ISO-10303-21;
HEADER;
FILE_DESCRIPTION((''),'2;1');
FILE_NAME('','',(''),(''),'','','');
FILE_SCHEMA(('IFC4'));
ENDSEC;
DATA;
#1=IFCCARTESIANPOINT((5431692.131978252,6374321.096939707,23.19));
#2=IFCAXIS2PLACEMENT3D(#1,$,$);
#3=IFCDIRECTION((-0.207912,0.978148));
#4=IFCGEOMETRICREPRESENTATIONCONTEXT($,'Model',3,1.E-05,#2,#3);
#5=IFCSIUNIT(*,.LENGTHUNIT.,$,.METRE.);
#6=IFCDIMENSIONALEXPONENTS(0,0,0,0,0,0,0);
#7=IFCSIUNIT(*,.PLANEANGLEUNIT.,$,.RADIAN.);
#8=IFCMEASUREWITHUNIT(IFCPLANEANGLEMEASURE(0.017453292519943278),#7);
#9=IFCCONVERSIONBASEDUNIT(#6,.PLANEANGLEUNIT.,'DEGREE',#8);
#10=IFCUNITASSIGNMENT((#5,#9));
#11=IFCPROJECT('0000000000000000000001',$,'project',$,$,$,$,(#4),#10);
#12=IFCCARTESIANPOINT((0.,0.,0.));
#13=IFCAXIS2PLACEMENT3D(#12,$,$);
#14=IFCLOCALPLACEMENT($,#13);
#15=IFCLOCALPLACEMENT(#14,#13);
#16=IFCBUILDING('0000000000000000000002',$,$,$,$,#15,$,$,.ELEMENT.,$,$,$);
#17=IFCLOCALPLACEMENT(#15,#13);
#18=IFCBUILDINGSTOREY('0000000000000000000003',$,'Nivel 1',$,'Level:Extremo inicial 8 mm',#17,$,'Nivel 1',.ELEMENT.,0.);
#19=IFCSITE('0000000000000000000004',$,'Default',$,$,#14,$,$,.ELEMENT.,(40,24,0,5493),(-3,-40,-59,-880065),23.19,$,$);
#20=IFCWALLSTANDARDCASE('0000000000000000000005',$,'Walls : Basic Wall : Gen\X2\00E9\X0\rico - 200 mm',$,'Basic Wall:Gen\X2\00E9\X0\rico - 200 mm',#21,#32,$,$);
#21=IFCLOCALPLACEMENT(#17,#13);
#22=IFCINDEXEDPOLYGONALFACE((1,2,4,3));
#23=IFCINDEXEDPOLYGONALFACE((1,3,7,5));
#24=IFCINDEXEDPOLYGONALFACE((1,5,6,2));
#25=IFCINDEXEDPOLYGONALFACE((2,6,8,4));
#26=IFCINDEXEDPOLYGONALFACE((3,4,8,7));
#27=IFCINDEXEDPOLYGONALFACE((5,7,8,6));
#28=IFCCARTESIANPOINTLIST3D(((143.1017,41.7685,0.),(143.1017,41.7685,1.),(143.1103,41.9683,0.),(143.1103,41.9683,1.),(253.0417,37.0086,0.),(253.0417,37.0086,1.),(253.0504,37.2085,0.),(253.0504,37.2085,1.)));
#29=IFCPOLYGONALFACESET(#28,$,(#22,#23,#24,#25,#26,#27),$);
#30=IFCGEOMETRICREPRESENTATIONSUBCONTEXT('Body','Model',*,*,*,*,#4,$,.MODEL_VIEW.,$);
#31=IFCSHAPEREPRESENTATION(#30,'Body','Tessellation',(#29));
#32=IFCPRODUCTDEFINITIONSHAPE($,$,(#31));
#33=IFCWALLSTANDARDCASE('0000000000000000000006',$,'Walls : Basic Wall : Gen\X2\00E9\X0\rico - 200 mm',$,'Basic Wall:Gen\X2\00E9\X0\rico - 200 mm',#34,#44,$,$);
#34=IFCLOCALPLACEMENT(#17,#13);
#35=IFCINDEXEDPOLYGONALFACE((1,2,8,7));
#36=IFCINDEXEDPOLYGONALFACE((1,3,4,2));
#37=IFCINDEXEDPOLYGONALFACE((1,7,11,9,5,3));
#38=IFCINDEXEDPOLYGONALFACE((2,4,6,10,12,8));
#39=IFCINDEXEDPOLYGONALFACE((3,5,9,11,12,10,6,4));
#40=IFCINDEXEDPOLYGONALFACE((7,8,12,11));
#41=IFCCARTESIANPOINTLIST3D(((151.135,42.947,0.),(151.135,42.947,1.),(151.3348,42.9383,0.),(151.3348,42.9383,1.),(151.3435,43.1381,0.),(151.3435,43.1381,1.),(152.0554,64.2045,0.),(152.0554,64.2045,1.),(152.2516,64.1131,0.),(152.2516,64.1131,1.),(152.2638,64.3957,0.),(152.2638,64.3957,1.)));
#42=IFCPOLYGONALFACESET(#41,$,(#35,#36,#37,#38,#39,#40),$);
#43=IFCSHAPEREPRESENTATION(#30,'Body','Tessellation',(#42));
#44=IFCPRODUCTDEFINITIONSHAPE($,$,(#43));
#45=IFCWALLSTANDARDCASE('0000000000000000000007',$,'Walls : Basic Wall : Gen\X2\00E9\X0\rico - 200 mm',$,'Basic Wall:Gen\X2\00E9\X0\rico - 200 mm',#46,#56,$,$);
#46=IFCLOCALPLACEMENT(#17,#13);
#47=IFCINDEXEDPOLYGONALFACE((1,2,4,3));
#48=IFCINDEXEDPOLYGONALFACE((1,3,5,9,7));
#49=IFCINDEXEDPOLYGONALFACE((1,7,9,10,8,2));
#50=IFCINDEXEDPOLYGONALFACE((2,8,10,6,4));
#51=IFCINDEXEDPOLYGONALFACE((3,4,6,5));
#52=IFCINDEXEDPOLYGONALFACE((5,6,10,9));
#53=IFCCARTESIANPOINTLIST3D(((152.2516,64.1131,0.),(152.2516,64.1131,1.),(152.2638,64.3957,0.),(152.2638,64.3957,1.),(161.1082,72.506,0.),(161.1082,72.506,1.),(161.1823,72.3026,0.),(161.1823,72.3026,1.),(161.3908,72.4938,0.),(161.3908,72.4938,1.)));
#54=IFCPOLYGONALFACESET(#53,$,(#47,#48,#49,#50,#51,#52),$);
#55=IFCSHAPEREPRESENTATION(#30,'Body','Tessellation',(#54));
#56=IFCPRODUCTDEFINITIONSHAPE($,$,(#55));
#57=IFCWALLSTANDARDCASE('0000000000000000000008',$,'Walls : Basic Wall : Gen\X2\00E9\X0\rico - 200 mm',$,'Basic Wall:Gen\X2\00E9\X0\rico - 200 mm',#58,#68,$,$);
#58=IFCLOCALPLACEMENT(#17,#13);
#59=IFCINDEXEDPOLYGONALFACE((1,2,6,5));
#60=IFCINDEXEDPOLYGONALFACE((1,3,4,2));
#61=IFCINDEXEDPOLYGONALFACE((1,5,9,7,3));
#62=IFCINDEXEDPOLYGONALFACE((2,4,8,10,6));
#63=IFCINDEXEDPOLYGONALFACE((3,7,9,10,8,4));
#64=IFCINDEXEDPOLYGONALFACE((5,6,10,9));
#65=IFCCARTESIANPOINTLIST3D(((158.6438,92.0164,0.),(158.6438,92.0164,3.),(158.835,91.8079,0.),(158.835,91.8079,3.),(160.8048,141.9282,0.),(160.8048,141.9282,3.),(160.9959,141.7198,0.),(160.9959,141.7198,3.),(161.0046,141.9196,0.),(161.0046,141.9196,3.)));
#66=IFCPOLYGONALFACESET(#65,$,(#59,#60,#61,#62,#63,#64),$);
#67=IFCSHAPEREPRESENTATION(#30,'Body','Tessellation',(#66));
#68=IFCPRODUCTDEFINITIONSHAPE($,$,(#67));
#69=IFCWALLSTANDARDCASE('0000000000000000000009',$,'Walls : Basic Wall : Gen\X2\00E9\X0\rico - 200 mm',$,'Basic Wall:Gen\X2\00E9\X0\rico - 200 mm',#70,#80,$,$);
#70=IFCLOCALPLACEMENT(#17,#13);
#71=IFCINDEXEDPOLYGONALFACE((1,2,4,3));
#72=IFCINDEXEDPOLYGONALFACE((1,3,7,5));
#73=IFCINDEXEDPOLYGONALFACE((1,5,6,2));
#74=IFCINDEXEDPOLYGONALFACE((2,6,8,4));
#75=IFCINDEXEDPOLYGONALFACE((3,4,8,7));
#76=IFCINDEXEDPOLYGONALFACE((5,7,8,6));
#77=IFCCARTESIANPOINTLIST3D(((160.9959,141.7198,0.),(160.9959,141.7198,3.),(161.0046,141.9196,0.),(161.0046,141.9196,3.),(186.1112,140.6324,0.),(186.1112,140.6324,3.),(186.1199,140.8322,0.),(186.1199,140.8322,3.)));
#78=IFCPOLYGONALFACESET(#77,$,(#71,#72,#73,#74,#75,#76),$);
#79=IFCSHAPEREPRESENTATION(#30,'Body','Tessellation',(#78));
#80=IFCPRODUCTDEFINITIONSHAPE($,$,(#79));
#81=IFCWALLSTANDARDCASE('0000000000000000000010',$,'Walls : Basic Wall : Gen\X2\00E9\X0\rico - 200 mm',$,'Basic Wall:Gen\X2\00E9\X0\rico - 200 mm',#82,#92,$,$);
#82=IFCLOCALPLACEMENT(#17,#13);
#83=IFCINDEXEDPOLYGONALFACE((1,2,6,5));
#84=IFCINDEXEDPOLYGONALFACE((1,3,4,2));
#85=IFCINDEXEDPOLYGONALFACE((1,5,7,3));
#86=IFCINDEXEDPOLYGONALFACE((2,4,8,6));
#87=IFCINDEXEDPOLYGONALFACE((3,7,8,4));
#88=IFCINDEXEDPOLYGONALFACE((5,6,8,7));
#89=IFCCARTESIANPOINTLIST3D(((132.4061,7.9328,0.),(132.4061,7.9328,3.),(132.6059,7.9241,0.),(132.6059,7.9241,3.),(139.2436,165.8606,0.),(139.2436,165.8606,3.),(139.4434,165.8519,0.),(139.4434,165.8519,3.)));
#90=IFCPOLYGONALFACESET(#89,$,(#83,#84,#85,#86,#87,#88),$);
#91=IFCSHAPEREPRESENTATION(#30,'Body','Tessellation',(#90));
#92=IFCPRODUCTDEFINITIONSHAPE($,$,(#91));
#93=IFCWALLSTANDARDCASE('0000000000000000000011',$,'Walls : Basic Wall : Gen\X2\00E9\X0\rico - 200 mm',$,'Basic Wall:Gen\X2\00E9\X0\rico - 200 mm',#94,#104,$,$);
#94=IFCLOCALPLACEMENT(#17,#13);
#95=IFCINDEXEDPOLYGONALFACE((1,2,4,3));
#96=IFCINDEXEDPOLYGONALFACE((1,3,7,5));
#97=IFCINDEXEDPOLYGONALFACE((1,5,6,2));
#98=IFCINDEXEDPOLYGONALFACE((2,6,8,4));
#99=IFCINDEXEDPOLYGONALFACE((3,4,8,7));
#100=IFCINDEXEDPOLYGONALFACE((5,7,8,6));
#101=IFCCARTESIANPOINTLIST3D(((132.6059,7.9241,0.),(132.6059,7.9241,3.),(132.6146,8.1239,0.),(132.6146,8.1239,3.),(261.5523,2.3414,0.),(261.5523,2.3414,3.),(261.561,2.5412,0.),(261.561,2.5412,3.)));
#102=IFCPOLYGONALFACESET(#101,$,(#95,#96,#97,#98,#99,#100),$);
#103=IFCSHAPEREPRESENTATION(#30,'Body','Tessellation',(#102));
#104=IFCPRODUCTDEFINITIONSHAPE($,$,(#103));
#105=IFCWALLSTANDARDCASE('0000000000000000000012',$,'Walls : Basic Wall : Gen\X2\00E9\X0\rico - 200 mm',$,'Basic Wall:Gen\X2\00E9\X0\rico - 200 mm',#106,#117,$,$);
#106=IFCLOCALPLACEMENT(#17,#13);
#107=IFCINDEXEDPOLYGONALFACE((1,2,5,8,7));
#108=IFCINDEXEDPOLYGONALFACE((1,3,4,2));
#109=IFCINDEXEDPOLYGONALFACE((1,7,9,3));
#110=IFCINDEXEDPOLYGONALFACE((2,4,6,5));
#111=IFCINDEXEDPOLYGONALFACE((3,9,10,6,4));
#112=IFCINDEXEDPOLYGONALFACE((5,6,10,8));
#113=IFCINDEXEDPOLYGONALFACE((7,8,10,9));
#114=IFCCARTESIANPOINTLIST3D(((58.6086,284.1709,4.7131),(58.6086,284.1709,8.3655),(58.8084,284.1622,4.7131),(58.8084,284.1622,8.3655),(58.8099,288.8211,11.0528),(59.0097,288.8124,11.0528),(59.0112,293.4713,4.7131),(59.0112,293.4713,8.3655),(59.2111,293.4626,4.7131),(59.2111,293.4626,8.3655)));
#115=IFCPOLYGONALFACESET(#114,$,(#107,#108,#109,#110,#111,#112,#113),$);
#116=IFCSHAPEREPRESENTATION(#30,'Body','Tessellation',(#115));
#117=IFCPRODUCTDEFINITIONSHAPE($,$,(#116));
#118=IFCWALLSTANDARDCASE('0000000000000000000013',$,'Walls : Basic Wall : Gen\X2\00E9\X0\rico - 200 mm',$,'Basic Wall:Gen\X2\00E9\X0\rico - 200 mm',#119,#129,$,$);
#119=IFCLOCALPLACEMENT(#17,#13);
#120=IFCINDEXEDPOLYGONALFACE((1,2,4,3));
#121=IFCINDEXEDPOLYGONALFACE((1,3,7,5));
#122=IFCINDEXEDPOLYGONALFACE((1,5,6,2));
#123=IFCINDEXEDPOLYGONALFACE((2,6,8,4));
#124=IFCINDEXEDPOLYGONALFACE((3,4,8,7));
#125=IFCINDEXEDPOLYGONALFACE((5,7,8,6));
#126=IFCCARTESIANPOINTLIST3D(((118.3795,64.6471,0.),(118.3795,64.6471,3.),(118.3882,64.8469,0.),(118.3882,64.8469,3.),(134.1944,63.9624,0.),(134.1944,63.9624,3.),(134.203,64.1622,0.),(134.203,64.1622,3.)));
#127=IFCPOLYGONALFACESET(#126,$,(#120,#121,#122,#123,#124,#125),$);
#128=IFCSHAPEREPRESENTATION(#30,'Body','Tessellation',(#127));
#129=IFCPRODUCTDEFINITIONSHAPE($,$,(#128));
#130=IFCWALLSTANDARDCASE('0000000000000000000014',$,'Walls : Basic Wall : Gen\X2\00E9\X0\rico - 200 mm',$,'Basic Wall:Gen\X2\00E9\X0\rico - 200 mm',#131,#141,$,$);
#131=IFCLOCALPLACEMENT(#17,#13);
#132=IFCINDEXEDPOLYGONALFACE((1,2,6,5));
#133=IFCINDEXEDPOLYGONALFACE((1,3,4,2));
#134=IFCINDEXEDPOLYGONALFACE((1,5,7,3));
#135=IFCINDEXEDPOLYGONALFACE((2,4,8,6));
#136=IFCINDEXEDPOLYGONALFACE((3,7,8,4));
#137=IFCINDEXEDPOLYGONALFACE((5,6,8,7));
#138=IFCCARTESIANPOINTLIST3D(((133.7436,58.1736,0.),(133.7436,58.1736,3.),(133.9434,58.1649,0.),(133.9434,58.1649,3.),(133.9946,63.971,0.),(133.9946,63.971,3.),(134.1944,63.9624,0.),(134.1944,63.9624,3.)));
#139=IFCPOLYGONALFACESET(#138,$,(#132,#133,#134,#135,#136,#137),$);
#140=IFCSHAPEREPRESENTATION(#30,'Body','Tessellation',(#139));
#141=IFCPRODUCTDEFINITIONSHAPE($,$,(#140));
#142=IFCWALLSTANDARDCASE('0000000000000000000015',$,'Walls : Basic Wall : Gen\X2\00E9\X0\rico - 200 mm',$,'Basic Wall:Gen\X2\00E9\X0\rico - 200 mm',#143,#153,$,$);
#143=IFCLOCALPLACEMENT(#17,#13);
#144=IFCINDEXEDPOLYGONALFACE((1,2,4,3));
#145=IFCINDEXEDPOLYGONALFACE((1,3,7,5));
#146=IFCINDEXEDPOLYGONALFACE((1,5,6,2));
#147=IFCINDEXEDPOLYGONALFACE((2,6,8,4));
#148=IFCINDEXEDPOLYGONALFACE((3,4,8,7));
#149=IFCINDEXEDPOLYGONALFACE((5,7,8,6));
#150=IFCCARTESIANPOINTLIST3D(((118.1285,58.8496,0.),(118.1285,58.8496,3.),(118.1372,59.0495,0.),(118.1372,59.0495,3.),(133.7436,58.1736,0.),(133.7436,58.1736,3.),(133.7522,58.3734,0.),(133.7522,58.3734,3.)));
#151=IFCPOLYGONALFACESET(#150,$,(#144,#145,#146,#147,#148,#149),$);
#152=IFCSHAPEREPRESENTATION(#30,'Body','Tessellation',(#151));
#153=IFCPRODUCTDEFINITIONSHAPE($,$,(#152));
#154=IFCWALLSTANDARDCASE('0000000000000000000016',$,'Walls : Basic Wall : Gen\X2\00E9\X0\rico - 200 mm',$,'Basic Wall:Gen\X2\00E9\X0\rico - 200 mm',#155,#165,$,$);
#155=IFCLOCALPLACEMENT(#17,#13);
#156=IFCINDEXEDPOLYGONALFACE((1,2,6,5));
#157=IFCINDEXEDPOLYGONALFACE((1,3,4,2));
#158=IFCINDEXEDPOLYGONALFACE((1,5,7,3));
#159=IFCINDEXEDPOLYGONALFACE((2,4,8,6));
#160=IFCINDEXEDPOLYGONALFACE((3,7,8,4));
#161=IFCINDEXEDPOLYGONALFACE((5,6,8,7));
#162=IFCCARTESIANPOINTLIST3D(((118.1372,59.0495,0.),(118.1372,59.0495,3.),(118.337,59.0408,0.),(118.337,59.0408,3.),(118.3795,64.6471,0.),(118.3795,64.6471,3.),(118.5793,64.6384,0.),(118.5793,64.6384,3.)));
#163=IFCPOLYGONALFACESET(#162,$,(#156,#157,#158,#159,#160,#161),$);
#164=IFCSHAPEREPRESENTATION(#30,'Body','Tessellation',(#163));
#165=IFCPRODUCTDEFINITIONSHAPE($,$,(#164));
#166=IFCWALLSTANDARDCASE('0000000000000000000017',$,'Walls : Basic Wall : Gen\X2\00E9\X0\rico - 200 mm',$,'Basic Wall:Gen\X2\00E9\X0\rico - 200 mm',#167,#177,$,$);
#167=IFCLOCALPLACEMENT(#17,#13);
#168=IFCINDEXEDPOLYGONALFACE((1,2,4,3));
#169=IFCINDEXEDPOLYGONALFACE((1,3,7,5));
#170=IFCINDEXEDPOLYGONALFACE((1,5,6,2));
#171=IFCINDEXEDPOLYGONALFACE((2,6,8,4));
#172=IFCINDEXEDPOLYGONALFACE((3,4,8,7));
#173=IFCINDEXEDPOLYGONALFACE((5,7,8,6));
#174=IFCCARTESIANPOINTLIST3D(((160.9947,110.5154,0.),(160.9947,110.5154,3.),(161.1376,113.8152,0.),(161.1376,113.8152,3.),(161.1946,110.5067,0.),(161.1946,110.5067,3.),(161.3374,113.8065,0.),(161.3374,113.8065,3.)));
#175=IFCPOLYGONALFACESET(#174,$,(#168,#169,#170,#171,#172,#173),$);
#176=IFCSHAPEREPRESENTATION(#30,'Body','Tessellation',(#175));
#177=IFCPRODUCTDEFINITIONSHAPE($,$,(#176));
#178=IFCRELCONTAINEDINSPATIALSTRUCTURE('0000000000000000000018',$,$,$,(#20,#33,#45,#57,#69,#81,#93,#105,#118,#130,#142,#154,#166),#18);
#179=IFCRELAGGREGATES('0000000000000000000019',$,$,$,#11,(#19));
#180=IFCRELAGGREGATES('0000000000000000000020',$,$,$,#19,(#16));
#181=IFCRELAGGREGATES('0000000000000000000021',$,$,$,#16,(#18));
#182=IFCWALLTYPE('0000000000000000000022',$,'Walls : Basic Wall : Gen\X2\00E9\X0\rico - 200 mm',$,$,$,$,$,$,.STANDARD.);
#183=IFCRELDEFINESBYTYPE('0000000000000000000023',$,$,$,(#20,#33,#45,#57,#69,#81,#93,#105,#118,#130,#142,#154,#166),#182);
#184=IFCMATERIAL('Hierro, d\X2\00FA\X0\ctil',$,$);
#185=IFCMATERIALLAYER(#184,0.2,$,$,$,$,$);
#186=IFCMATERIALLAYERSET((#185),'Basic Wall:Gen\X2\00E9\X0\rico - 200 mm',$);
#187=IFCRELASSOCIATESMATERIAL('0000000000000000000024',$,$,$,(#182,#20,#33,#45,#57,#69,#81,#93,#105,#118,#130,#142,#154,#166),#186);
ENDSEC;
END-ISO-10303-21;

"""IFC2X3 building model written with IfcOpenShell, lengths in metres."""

from ifc_helpers import new_model, entity, si_unit, converted_unit, direction, frame, frame_2d, origin, place, context, subcontext, project, spatial, polyline, rectangle, outline, extrude, clip, bounded_halfspace, material, layer, layer_set, layer_usage, type_object, element, save


model = new_model("IFC2X3")

# Units and contexts
model_context = context("Model", 3, precision=1e-05, world=frame((5431692.131978252, 6374321.096939707, 23.19)), true_north=direction((-0.207912, 0.978148)))
body_context = subcontext(model_context, "Body", "Model", "MODEL_VIEW")
ifc_project = project(units=[si_unit("LENGTHUNIT", "METRE"), converted_unit("PLANEANGLEUNIT", "DEGREE", entity("IfcPlaneAngleMeasure", 0.017453292519943278), si_unit("PLANEANGLEUNIT", "RADIAN"), dimensions=[0, 0, 0, 0, 0, 0, 0])], contexts=[model_context])

# Site, building, storey
site_placement = place(None, origin())
site = spatial("IfcSite", under=ifc_project, at=site_placement, Name="Default", CompositionType="ELEMENT", RefLatitude=(40, 24, 0, 5493), RefLongitude=(-3, -40, -59, -880065), RefElevation=23.19)
building_placement = place(site_placement, origin())
building = spatial("IfcBuilding", under=site, at=building_placement, CompositionType="ELEMENT")
storey_placement = place(building_placement, origin())
storey = spatial("IfcBuildingStorey", under=building, at=storey_placement, Name="Nivel 1", ObjectType="Level:Extremo inicial 8 mm", LongName="Nivel 1", CompositionType="ELEMENT", Elevation=0.0)

# Walls
ifc_material_1 = material(Name="Hierro, dúctil")
ifc_layer = layer(ifc_material_1, 0.2)
ifc_layer_set = layer_set([ifc_layer], Name="Basic Wall:Genérico - 200 mm")
wall_type = type_object("IfcWallType", Name="Walls : Basic Wall : Genérico - 200 mm", PredefinedType="STANDARD", material=ifc_layer_set)
ifc_layer_usage_1 = layer_usage(ifc_layer_set, "AXIS2", "NEGATIVE", 0.1)
wall_1_placement = place(storey_placement, frame((143.106, 41.8684, 0.0), z_axis=(0.0, 0.0, 1.0), x_axis=(0.999064, -0.043255, 0.0)))
element("IfcWallStandardCase", 1, at=wall_1_placement, inside=storey, type_object=wall_type, material=ifc_layer_usage_1, Name="Walls : Basic Wall : Genérico - 200 mm", ObjectType="Basic Wall:Genérico - 200 mm", context=body_context, shape_type="SweptSolid", body=[
    extrude(rectangle(XDim=110.0431, YDim=0.2, at=frame_2d((55.0215, 0.0), x_axis=(-1.0, 0.0))), origin(), (0.0, 0.0, 1.0), 1.0),
])
ifc_layer_usage_2 = layer_usage(ifc_layer_set, "AXIS2", "NEGATIVE", 0.1)
wall_2_placement = place(storey_placement, frame((151.2349, 42.9426, 0.0), z_axis=(0.0, 0.0, 1.0), x_axis=(0.043255, 0.999064, 0.0)))
element("IfcWallStandardCase", 2, at=wall_2_placement, inside=storey, type_object=wall_type, material=ifc_layer_usage_2, Name="Walls : Basic Wall : Genérico - 200 mm", ObjectType="Basic Wall:Genérico - 200 mm", context=body_context, shape_type="SweptSolid", body=[
    extrude(outline(polyline([(21.4775, -0.1), (21.2775, 0.1), (0.0, 0.1), (0.0, -0.1), (0.2, -0.1), (21.1946, -0.1), (21.4775, -0.1)])), origin(), (0.0, 0.0, 1.0), 1.0),
])
ifc_layer_usage_3 = layer_usage(ifc_layer_set, "AXIS2", "NEGATIVE", 0.1)
wall_3_placement = place(storey_placement, frame((152.184, 64.1868, 0.0), z_axis=(0.0, 0.0, 1.0), x_axis=(0.737031, 0.675859, 0.0)))
element("IfcWallStandardCase", 3, at=wall_3_placement, inside=storey, type_object=wall_type, material=ifc_layer_usage_3, Name="Walls : Basic Wall : Genérico - 200 mm", ObjectType="Basic Wall:Genérico - 200 mm", context=body_context, shape_type="SweptSolid", body=[
    extrude(outline(polyline([(12.4, -0.1), (12.2, 0.1), (0.2, 0.1), (0.0, -0.1), (12.1172, -0.1), (12.4, -0.1)])), origin(), (0.0, 0.0, 1.0), 1.0),
])
ifc_layer_usage_4 = layer_usage(ifc_layer_set, "AXIS2", "NEGATIVE", 0.1)
wall_4_placement = place(storey_placement, frame((158.7351, 91.8123, 0.0), z_axis=(0.0, 0.0, 1.0), x_axis=(0.043255, 0.999064, 0.0)))
element("IfcWallStandardCase", 4, at=wall_4_placement, inside=storey, type_object=wall_type, material=ifc_layer_usage_4, Name="Walls : Basic Wall : Genérico - 200 mm", ObjectType="Basic Wall:Genérico - 200 mm", context=body_context, shape_type="SweptSolid", body=[
    extrude(outline(polyline([(50.1586, -0.1), (50.1586, 0.1), (0.2, 0.1), (0.0, -0.1), (49.9586, -0.1), (50.1586, -0.1)])), origin(), (0.0, 0.0, 1.0), 3.0),
])
ifc_layer_usage_5 = layer_usage(ifc_layer_set, "AXIS2", "NEGATIVE", 0.1)
wall_5_placement = place(storey_placement, frame((161.0003, 141.8197, 0.0), z_axis=(0.0, 0.0, 1.0), x_axis=(0.999064, -0.043255, 0.0)))
element("IfcWallStandardCase", 5, at=wall_5_placement, inside=storey, type_object=wall_type, material=ifc_layer_usage_5, Name="Walls : Basic Wall : Genérico - 200 mm", ObjectType="Basic Wall:Genérico - 200 mm", context=body_context, shape_type="SweptSolid", body=[
    extrude(rectangle(XDim=25.1388, YDim=0.2, at=frame_2d((12.5694, 0.0), x_axis=(-1.0, 0.0))), origin(), (0.0, 0.0, 1.0), 3.0),
])
ifc_layer_usage_6 = layer_usage(ifc_layer_set, "AXIS2", "NEGATIVE", 0.1)
wall_6_placement = place(storey_placement, frame((139.3435, 165.8562, 0.0), z_axis=(0.0, 0.0, 1.0), x_axis=(-0.043255, -0.999064, 0.0)))
element("IfcWallStandardCase", 6, at=wall_6_placement, inside=storey, type_object=wall_type, material=ifc_layer_usage_6, Name="Walls : Basic Wall : Genérico - 200 mm", ObjectType="Basic Wall:Genérico - 200 mm", context=body_context, shape_type="SweptSolid", body=[
    extrude(rectangle(XDim=158.0757, YDim=0.2, at=frame_2d((79.0379, 0.0), x_axis=(-1.0, 0.0))), origin(), (0.0, 0.0, 1.0), 3.0),
])
ifc_layer_usage_7 = layer_usage(ifc_layer_set, "AXIS2", "NEGATIVE", 0.1)
wall_7_placement = place(storey_placement, frame((132.6102, 8.024, 0.0), z_axis=(0.0, 0.0, 1.0), x_axis=(0.999064, -0.043255, 0.0)))
element("IfcWallStandardCase", 7, at=wall_7_placement, inside=storey, type_object=wall_type, material=ifc_layer_usage_7, Name="Walls : Basic Wall : Genérico - 200 mm", ObjectType="Basic Wall:Genérico - 200 mm", context=body_context, shape_type="SweptSolid", body=[
    extrude(rectangle(XDim=129.0672, YDim=0.2, at=frame_2d((64.5336, 0.0), x_axis=(-1.0, 0.0))), origin(), (0.0, 0.0, 1.0), 3.0),
])
ifc_layer_usage_8 = layer_usage(ifc_layer_set, "AXIS2", "NEGATIVE", 0.1)
wall_8_placement = place(storey_placement, frame((59.1111, 293.4669, 4.7131), z_axis=(0.0, 0.0, 1.0), x_axis=(-0.043255, -0.999064, 0.0)))
element("IfcWallStandardCase", 8, at=wall_8_placement, inside=storey, type_object=wall_type, material=ifc_layer_usage_8, Name="Walls : Basic Wall : Genérico - 200 mm", ObjectType="Basic Wall:Genérico - 200 mm", context=body_context, shape_type="Clipping", body=[
    clip(clip(extrude(rectangle(XDim=9.3091, YDim=0.2, at=frame_2d((4.6546, 0.0), x_axis=(-1.0, 0.0))), origin(), (0.0, 0.0, 1.0), 6.3397), bounded_halfspace(frame((0.0, -0.1, 3.6524), z_axis=(-0.5, 0.0, 0.866025), x_axis=(0.0, -1.0, 0.0)), False, frame((0.0, -0.1, 3.6524)), polyline([(0.0, 0.0), (4.6546, 0.0), (4.6546, 0.2), (0.0, 0.2), (0.0, 0.0)]))), bounded_halfspace(frame((4.6546, -0.1, 6.3397), z_axis=(0.5, 0.0, 0.866025), x_axis=(0.0, 1.0, 0.0)), False, frame((4.6546, -0.1, 6.3397)), polyline([(0.0, 0.0), (4.6546, 0.0), (4.6546, 0.2), (0.0, 0.2), (0.0, 0.0)]))),
])
ifc_layer_usage_9 = layer_usage(ifc_layer_set, "AXIS2", "NEGATIVE", 0.1)
wall_9_placement = place(storey_placement, frame((118.3838, 64.747, 0.0), z_axis=(0.0, 0.0, 1.0), x_axis=(0.999064, -0.043255, 0.0)))
element("IfcWallStandardCase", 9, at=wall_9_placement, inside=storey, type_object=wall_type, material=ifc_layer_usage_9, Name="Walls : Basic Wall : Genérico - 200 mm", ObjectType="Basic Wall:Genérico - 200 mm", context=body_context, shape_type="SweptSolid", body=[
    extrude(rectangle(XDim=15.8297, YDim=0.2, at=frame_2d((7.9148, 0.0), x_axis=(-1.0, 0.0))), origin(), (0.0, 0.0, 1.0), 3.0),
])
ifc_layer_usage_10 = layer_usage(ifc_layer_set, "AXIS2", "NEGATIVE", 0.1)
wall_10_placement = place(storey_placement, frame((134.0945, 63.9667, 0.0), z_axis=(0.0, 0.0, 1.0), x_axis=(-0.043255, -0.999064, 0.0)))
element("IfcWallStandardCase", 10, at=wall_10_placement, inside=storey, type_object=wall_type, material=ifc_layer_usage_10, Name="Walls : Basic Wall : Genérico - 200 mm", ObjectType="Basic Wall:Genérico - 200 mm", context=body_context, shape_type="SweptSolid", body=[
    extrude(rectangle(XDim=5.8029, YDim=0.2, at=frame_2d((2.9014, 0.0), x_axis=(-1.0, 0.0))), origin(), (0.0, 0.0, 1.0), 3.0),
])
ifc_layer_usage_11 = layer_usage(ifc_layer_set, "AXIS2", "NEGATIVE", 0.1)
wall_11_placement = place(storey_placement, frame((133.7479, 58.2735, 0.0), z_axis=(0.0, 0.0, 1.0), x_axis=(-0.999064, 0.043255, 0.0)))
element("IfcWallStandardCase", 11, at=wall_11_placement, inside=storey, type_object=wall_type, material=ifc_layer_usage_11, Name="Walls : Basic Wall : Genérico - 200 mm", ObjectType="Basic Wall:Genérico - 200 mm", context=body_context, shape_type="SweptSolid", body=[
    extrude(rectangle(XDim=15.6297, YDim=0.2, at=frame_2d((7.8148, 0.0), x_axis=(-1.0, 0.0))), origin(), (0.0, 0.0, 1.0), 3.0),
])
ifc_layer_usage_12 = layer_usage(ifc_layer_set, "AXIS2", "NEGATIVE", 0.1)
wall_12_placement = place(storey_placement, frame((118.2371, 59.0451, 0.0), z_axis=(0.0, 0.0, 1.0), x_axis=(0.043255, 0.999064, 0.0)))
element("IfcWallStandardCase", 12, at=wall_12_placement, inside=storey, type_object=wall_type, material=ifc_layer_usage_12, Name="Walls : Basic Wall : Genérico - 200 mm", ObjectType="Basic Wall:Genérico - 200 mm", context=body_context, shape_type="SweptSolid", body=[
    extrude(rectangle(XDim=5.6029, YDim=0.2, at=frame_2d((2.8014, 0.0), x_axis=(-1.0, 0.0))), origin(), (0.0, 0.0, 1.0), 3.0),
])
ifc_layer_usage_13 = layer_usage(ifc_layer_set, "AXIS2", "NEGATIVE", 0.1)
wall_13_placement = place(storey_placement, frame((161.0946, 110.511, 0.0), z_axis=(0.0, 0.0, 1.0), x_axis=(0.043255, 0.999064, 0.0)))
element("IfcWallStandardCase", 13, at=wall_13_placement, inside=storey, type_object=wall_type, material=ifc_layer_usage_13, Name="Walls : Basic Wall : Genérico - 200 mm", ObjectType="Basic Wall:Genérico - 200 mm", context=body_context, shape_type="SweptSolid", body=[
    extrude(rectangle(XDim=3.3029, YDim=0.2, at=frame_2d((1.6514, 0.0), x_axis=(-1.0, 0.0))), origin(), (0.0, 0.0, 1.0), 3.0),
])

save(model, "model.ifc")
